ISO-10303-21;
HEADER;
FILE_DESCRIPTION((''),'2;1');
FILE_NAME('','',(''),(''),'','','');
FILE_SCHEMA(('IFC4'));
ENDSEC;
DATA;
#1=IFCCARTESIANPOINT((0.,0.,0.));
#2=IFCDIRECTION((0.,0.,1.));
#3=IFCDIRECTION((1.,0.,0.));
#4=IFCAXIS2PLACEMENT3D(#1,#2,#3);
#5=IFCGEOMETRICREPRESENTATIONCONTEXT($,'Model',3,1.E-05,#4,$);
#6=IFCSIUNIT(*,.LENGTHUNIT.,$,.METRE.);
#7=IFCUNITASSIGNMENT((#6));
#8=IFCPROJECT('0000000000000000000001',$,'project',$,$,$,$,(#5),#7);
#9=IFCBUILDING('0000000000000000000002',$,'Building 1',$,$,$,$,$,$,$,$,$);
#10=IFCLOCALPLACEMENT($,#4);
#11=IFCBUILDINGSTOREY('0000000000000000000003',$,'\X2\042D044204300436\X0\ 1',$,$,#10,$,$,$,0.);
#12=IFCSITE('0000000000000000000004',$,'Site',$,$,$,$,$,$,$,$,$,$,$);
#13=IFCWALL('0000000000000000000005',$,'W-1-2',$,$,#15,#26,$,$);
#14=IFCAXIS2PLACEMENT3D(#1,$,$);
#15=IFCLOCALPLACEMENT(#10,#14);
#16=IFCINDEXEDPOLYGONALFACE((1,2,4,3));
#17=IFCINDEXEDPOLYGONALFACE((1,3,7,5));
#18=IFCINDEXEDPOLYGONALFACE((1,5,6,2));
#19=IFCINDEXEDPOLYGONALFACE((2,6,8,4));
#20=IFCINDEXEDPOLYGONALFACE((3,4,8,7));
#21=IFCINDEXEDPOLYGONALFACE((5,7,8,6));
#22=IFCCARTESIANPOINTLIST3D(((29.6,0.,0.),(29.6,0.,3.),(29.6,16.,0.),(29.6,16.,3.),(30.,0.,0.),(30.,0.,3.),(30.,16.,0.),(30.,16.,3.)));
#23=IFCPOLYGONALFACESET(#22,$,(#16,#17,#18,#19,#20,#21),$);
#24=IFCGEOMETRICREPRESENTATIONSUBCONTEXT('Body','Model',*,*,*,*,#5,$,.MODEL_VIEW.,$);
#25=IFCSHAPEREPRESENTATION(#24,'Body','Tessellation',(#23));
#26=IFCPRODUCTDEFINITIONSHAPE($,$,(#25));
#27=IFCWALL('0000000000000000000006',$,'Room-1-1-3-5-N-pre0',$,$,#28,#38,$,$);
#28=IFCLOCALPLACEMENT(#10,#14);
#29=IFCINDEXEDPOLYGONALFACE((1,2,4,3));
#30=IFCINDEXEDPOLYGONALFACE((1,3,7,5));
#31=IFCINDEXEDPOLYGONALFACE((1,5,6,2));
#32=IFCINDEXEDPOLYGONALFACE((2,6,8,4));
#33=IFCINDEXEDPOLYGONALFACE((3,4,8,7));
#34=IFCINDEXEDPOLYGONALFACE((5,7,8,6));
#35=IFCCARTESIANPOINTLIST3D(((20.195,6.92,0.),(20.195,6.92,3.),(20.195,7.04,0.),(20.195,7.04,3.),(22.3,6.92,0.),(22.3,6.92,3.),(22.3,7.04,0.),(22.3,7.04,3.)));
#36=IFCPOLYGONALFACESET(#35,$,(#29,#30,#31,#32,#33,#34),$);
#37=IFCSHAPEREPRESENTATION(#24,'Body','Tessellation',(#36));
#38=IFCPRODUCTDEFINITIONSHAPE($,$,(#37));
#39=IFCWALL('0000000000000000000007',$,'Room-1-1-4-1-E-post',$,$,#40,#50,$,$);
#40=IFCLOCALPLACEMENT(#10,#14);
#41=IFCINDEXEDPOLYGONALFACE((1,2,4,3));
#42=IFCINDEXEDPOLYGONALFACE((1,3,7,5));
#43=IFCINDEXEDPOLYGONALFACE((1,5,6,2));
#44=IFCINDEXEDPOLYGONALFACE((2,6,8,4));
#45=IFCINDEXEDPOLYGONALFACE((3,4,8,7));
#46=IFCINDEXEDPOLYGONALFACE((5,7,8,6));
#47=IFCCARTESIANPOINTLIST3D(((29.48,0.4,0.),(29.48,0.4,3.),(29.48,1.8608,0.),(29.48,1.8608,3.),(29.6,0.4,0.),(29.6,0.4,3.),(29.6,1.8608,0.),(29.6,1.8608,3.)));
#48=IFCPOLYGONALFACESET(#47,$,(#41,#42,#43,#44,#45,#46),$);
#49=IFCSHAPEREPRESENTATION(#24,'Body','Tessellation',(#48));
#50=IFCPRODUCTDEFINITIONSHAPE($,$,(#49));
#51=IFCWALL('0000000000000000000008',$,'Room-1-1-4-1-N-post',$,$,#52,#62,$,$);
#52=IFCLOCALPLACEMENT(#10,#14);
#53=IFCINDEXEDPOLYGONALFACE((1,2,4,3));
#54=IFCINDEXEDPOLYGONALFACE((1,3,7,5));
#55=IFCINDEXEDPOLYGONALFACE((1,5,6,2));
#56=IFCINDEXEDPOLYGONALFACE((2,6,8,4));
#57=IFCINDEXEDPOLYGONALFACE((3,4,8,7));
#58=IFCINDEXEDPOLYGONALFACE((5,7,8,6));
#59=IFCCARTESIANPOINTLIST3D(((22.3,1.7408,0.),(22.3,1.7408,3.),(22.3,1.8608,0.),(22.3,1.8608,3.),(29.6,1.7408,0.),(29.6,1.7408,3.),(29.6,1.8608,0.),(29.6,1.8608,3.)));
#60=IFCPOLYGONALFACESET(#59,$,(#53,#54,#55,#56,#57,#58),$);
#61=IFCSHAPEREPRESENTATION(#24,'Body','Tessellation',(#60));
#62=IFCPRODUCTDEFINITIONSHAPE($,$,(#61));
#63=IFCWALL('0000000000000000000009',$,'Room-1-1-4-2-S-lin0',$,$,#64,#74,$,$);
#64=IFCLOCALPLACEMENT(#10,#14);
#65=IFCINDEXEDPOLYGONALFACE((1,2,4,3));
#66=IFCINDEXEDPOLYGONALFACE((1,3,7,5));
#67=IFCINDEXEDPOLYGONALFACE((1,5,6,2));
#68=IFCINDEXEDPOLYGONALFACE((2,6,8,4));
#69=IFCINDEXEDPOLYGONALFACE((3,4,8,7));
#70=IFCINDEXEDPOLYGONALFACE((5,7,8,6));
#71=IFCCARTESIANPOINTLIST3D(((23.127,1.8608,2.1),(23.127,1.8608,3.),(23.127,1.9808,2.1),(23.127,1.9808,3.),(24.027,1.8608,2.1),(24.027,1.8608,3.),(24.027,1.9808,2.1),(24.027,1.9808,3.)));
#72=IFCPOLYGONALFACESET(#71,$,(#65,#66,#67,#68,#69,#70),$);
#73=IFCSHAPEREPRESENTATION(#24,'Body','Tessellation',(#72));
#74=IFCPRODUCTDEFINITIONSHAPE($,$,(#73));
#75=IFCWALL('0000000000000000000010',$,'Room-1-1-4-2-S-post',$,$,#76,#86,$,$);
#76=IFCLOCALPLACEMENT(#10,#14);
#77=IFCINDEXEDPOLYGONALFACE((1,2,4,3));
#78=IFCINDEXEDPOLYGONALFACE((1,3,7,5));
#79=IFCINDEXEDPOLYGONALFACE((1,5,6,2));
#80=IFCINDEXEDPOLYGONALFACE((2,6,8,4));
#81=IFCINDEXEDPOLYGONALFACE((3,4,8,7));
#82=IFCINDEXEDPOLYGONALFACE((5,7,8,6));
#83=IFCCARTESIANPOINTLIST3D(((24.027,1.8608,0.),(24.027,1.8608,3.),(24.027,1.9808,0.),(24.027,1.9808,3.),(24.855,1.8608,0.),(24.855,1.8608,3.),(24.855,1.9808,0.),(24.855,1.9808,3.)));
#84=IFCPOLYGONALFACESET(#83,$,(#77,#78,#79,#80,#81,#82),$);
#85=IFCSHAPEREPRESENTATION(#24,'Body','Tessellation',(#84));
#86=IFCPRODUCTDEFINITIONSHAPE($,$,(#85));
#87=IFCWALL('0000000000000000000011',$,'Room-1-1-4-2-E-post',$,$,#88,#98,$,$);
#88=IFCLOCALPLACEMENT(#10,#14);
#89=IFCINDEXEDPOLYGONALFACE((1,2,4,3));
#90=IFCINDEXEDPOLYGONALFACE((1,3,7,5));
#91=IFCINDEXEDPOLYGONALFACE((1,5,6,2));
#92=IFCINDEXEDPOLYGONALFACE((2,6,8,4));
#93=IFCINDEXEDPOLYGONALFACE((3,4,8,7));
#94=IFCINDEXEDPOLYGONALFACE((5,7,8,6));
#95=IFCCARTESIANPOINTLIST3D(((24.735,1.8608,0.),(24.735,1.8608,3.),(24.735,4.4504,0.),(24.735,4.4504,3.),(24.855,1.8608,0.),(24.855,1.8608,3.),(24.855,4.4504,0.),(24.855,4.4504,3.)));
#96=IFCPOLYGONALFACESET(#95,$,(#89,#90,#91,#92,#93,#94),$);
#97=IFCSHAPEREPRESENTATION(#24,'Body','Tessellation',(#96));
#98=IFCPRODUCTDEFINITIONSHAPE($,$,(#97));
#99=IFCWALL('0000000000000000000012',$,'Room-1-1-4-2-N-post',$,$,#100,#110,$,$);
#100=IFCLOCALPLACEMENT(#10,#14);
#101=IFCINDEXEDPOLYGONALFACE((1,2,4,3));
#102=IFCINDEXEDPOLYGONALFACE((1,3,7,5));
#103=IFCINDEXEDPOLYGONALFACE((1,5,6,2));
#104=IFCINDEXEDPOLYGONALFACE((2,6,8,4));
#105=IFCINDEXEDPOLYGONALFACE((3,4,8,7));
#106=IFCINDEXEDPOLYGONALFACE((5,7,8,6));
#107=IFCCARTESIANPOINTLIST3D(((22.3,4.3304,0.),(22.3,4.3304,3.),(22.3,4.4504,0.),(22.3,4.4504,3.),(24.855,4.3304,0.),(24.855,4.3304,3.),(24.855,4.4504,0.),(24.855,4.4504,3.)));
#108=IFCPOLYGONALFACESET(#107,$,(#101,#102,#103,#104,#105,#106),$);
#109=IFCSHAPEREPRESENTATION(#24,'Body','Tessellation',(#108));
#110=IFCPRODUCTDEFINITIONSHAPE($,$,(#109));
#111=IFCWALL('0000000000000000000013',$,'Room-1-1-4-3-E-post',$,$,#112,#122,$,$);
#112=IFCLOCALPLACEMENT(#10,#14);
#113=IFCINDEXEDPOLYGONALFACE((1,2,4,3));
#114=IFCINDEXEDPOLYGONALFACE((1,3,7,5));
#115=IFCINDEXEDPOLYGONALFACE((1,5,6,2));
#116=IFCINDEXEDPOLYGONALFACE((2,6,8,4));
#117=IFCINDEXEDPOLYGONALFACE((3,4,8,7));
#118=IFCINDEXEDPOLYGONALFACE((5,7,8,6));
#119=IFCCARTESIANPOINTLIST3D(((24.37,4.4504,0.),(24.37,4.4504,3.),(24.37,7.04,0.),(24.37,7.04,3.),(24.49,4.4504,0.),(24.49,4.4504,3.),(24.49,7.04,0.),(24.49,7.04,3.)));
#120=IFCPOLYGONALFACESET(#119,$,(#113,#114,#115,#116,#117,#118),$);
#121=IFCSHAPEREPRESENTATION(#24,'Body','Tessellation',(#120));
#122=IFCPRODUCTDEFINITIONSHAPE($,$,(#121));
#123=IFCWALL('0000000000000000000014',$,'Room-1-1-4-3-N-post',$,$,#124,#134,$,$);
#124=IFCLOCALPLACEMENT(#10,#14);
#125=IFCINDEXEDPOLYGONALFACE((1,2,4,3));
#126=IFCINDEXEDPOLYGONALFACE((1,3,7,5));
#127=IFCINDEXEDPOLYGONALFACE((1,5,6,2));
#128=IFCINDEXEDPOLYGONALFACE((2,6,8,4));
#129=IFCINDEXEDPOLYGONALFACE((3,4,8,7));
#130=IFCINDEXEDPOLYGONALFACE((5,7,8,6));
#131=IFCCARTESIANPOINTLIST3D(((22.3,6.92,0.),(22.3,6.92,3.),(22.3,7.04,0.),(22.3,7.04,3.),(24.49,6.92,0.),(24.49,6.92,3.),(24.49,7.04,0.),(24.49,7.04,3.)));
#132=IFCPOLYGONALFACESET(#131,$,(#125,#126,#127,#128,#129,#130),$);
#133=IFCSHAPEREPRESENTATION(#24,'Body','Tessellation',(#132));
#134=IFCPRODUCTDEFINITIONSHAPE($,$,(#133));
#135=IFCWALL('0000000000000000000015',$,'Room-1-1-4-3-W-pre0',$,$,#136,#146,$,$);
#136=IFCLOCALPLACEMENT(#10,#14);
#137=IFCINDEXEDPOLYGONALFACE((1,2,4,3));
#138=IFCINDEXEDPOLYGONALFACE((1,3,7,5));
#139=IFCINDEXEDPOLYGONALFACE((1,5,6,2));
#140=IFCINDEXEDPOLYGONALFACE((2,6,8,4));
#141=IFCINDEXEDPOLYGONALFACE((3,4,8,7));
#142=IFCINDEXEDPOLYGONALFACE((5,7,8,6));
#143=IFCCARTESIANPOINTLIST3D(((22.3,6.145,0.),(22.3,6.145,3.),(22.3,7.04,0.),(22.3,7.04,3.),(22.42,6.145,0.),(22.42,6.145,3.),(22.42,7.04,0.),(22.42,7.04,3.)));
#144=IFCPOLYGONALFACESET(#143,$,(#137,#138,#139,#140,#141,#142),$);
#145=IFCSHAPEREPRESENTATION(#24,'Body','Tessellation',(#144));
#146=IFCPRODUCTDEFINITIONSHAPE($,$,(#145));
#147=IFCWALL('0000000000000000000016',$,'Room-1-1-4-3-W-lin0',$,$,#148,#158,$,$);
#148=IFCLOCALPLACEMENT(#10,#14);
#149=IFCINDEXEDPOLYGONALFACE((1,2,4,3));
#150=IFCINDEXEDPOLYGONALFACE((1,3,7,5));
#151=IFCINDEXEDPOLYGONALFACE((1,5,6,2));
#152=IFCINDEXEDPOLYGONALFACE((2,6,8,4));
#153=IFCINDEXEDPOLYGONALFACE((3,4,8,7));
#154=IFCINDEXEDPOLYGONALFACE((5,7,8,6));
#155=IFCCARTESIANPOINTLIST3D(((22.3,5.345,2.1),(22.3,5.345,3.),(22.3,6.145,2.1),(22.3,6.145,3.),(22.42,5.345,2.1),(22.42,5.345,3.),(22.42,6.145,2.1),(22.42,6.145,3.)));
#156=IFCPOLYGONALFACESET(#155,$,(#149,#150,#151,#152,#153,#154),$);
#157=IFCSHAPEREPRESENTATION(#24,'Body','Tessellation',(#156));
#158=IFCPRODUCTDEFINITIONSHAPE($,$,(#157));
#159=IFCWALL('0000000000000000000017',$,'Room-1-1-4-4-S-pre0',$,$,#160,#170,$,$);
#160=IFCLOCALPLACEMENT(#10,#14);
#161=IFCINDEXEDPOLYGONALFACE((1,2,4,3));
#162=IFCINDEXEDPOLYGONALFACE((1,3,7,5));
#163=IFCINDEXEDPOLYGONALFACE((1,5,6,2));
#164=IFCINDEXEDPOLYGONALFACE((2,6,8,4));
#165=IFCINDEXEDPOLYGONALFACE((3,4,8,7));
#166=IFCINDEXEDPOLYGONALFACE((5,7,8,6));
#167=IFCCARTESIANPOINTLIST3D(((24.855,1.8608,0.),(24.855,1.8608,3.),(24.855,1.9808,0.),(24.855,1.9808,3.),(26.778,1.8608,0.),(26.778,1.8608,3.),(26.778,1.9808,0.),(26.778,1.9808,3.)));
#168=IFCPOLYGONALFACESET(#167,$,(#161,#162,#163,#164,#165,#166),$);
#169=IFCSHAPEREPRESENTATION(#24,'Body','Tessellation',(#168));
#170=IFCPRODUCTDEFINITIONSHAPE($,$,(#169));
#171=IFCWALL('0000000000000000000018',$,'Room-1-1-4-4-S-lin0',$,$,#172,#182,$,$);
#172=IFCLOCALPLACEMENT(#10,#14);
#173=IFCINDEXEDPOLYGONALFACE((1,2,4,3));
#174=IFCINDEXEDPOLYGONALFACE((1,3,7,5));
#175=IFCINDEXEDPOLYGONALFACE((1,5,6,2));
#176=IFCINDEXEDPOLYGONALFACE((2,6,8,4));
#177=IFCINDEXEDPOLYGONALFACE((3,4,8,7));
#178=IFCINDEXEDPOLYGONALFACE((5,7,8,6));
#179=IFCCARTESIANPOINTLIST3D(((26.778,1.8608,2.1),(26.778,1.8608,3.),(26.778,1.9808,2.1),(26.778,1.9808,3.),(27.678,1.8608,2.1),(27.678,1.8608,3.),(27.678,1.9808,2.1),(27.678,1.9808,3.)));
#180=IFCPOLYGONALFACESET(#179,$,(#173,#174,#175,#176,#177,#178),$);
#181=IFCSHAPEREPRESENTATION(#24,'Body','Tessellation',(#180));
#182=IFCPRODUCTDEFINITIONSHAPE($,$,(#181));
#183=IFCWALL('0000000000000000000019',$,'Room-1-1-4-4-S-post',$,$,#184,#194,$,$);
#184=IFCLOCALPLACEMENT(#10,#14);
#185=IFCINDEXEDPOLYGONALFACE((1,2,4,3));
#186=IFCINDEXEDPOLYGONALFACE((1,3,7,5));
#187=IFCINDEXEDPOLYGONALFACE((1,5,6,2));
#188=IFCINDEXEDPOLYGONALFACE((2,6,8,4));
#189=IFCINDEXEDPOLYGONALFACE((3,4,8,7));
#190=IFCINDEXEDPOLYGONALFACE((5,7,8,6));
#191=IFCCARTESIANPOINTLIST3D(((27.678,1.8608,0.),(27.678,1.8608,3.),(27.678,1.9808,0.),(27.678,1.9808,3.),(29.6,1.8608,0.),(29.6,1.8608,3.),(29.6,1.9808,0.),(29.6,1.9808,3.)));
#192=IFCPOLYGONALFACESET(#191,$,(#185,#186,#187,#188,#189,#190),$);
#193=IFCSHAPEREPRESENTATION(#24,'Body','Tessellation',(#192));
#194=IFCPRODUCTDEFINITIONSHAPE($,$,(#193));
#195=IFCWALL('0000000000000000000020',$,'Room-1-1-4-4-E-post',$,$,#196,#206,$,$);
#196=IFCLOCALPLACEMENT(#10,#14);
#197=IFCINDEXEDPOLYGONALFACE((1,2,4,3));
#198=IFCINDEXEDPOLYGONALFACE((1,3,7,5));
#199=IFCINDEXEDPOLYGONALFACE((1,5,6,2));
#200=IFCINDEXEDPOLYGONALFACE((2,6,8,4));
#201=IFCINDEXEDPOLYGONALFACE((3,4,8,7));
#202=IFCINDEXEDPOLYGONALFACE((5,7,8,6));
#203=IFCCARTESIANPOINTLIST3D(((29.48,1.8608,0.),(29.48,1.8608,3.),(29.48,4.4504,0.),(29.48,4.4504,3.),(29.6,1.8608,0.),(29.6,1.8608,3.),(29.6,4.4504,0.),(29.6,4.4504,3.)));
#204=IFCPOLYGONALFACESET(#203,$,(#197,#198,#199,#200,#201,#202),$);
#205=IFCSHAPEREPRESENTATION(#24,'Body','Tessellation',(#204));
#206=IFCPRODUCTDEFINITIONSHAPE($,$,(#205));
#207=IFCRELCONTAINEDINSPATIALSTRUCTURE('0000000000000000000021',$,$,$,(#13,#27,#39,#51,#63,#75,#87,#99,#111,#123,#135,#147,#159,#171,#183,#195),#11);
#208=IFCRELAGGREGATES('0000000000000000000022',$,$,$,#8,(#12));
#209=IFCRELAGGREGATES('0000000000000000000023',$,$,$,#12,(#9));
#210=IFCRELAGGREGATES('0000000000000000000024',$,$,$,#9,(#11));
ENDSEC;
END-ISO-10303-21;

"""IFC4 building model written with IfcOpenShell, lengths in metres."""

from ifc_helpers import new_model, si_unit, frame, origin_with_axes, place, context, subcontext, project, spatial, indexed_curve, outline, extrude, element, save


model = new_model("IFC4")

# Units and contexts
model_context = context("Model", 3, precision=1e-05, world=origin_with_axes())
body_context = subcontext(model_context, "Body", "Model", "MODEL_VIEW")
ifc_project = project(units=[si_unit("LENGTHUNIT", "METRE")], contexts=[model_context])

# Site, building, storey
site = spatial("IfcSite", under=ifc_project, Name="Site")
building = spatial("IfcBuilding", under=site, Name="Building 1")
storey_placement = place(None, origin_with_axes())
storey = spatial("IfcBuildingStorey", under=building, at=storey_placement, Name="Этаж 1", Elevation=0.0)

# Walls
wall_1_placement = place(storey_placement, frame((30.0, 0.0, 0.0), z_axis=(0.0, 0.0, 1.0), x_axis=(0.0, 1.0, 0.0)))
element("IfcWall", 1, at=wall_1_placement, inside=storey, Name="W-1-2", context=body_context, shape_type="SweptSolid", body=[
    extrude(outline(indexed_curve([(0.0, 0.0), (0.0, 0.4), (16.0, 0.4), (16.0, 0.0), (0.0, 0.0)], self_intersect=False)), origin_with_axes(), (0.0, 0.0, 1.0), 3.0),
])
wall_2_placement = place(storey_placement, frame((22.3, 7.04, 0.0), z_axis=(0.0, 0.0, 1.0), x_axis=(-1.0, 0.0, 0.0)))
element("IfcWall", 2, at=wall_2_placement, inside=storey, Name="Room-1-1-3-5-N-pre0", context=body_context, shape_type="SweptSolid", body=[
    extrude(outline(indexed_curve([(0.0, 0.0), (0.0, 0.12), (2.105, 0.12), (2.105, 0.0), (0.0, 0.0)], self_intersect=False)), origin_with_axes(), (0.0, 0.0, 1.0), 3.0),
])
wall_3_placement = place(storey_placement, frame((29.6, 0.4, 0.0), z_axis=(0.0, 0.0, 1.0), x_axis=(0.0, 1.0, 0.0)))
element("IfcWall", 3, at=wall_3_placement, inside=storey, Name="Room-1-1-4-1-E-post", context=body_context, shape_type="SweptSolid", body=[
    extrude(outline(indexed_curve([(0.0, 0.0), (0.0, 0.12), (1.4608, 0.12), (1.4608, 0.0), (0.0, 0.0)], self_intersect=False)), origin_with_axes(), (0.0, 0.0, 1.0), 3.0),
])
wall_4_placement = place(storey_placement, frame((29.6, 1.8608, 0.0), z_axis=(0.0, 0.0, 1.0), x_axis=(-1.0, 0.0, 0.0)))
element("IfcWall", 4, at=wall_4_placement, inside=storey, Name="Room-1-1-4-1-N-post", context=body_context, shape_type="SweptSolid", body=[
    extrude(outline(indexed_curve([(0.0, 0.0), (0.0, 0.12), (7.3, 0.12), (7.3, 0.0), (0.0, 0.0)], self_intersect=False)), origin_with_axes(), (0.0, 0.0, 1.0), 3.0),
])
wall_5_placement = place(storey_placement, frame((23.127, 1.8608, 2.1), z_axis=(0.0, 0.0, 1.0), x_axis=(1.0, 0.0, 0.0)))
element("IfcWall", 5, at=wall_5_placement, inside=storey, Name="Room-1-1-4-2-S-lin0", context=body_context, shape_type="SweptSolid", body=[
    extrude(outline(indexed_curve([(0.0, 0.0), (0.0, 0.12), (0.9, 0.12), (0.9, 0.0), (0.0, 0.0)], self_intersect=False)), origin_with_axes(), (0.0, 0.0, 1.0), 0.9),
])
wall_6_placement = place(storey_placement, frame((24.027, 1.8608, 0.0), z_axis=(0.0, 0.0, 1.0), x_axis=(1.0, 0.0, 0.0)))
element("IfcWall", 6, at=wall_6_placement, inside=storey, Name="Room-1-1-4-2-S-post", context=body_context, shape_type="SweptSolid", body=[
    extrude(outline(indexed_curve([(0.0, 0.0), (0.0, 0.12), (0.828, 0.12), (0.828, 0.0), (0.0, 0.0)], self_intersect=False)), origin_with_axes(), (0.0, 0.0, 1.0), 3.0),
])
wall_7_placement = place(storey_placement, frame((24.855, 1.8608, 0.0), z_axis=(0.0, 0.0, 1.0), x_axis=(0.0, 1.0, 0.0)))
element("IfcWall", 7, at=wall_7_placement, inside=storey, Name="Room-1-1-4-2-E-post", context=body_context, shape_type="SweptSolid", body=[
    extrude(outline(indexed_curve([(0.0, 0.0), (0.0, 0.12), (2.5896, 0.12), (2.5896, 0.0), (0.0, 0.0)], self_intersect=False)), origin_with_axes(), (0.0, 0.0, 1.0), 3.0),
])
wall_8_placement = place(storey_placement, frame((24.855, 4.4504, 0.0), z_axis=(0.0, 0.0, 1.0), x_axis=(-1.0, 0.0, 0.0)))
element("IfcWall", 8, at=wall_8_placement, inside=storey, Name="Room-1-1-4-2-N-post", context=body_context, shape_type="SweptSolid", body=[
    extrude(outline(indexed_curve([(0.0, 0.0), (0.0, 0.12), (2.555, 0.12), (2.555, 0.0), (0.0, 0.0)], self_intersect=False)), origin_with_axes(), (0.0, 0.0, 1.0), 3.0),
])
wall_9_placement = place(storey_placement, frame((24.49, 4.4504, 0.0), z_axis=(0.0, 0.0, 1.0), x_axis=(0.0, 1.0, 0.0)))
element("IfcWall", 9, at=wall_9_placement, inside=storey, Name="Room-1-1-4-3-E-post", context=body_context, shape_type="SweptSolid", body=[
    extrude(outline(indexed_curve([(0.0, 0.0), (0.0, 0.12), (2.5896, 0.12), (2.5896, 0.0), (0.0, 0.0)], self_intersect=False)), origin_with_axes(), (0.0, 0.0, 1.0), 3.0),
])
wall_10_placement = place(storey_placement, frame((24.49, 7.04, 0.0), z_axis=(0.0, 0.0, 1.0), x_axis=(-1.0, 0.0, 0.0)))
element("IfcWall", 10, at=wall_10_placement, inside=storey, Name="Room-1-1-4-3-N-post", context=body_context, shape_type="SweptSolid", body=[
    extrude(outline(indexed_curve([(0.0, 0.0), (0.0, 0.12), (2.19, 0.12), (2.19, 0.0), (0.0, 0.0)], self_intersect=False)), origin_with_axes(), (0.0, 0.0, 1.0), 3.0),
])
wall_11_placement = place(storey_placement, frame((22.3, 7.04, 0.0), z_axis=(0.0, 0.0, 1.0), x_axis=(0.0, -1.0, 0.0)))
element("IfcWall", 11, at=wall_11_placement, inside=storey, Name="Room-1-1-4-3-W-pre0", context=body_context, shape_type="SweptSolid", body=[
    extrude(outline(indexed_curve([(0.0, 0.0), (0.0, 0.12), (0.895, 0.12), (0.895, 0.0), (0.0, 0.0)], self_intersect=False)), origin_with_axes(), (0.0, 0.0, 1.0), 3.0),
])
wall_12_placement = place(storey_placement, frame((22.3, 6.145, 2.1), z_axis=(0.0, 0.0, 1.0), x_axis=(0.0, -1.0, 0.0)))
element("IfcWall", 12, at=wall_12_placement, inside=storey, Name="Room-1-1-4-3-W-lin0", context=body_context, shape_type="SweptSolid", body=[
    extrude(outline(indexed_curve([(0.0, 0.0), (0.0, 0.12), (0.8, 0.12), (0.8, 0.0), (0.0, 0.0)], self_intersect=False)), origin_with_axes(), (0.0, 0.0, 1.0), 0.9),
])
wall_13_placement = place(storey_placement, frame((24.855, 1.8608, 0.0), z_axis=(0.0, 0.0, 1.0), x_axis=(1.0, 0.0, 0.0)))
element("IfcWall", 13, at=wall_13_placement, inside=storey, Name="Room-1-1-4-4-S-pre0", context=body_context, shape_type="SweptSolid", body=[
    extrude(outline(indexed_curve([(0.0, 0.0), (0.0, 0.12), (1.923, 0.12), (1.923, 0.0), (0.0, 0.0)], self_intersect=False)), origin_with_axes(), (0.0, 0.0, 1.0), 3.0),
])
wall_14_placement = place(storey_placement, frame((26.778, 1.8608, 2.1), z_axis=(0.0, 0.0, 1.0), x_axis=(1.0, 0.0, 0.0)))
element("IfcWall", 14, at=wall_14_placement, inside=storey, Name="Room-1-1-4-4-S-lin0", context=body_context, shape_type="SweptSolid", body=[
    extrude(outline(indexed_curve([(0.0, 0.0), (0.0, 0.12), (0.9, 0.12), (0.9, 0.0), (0.0, 0.0)], self_intersect=False)), origin_with_axes(), (0.0, 0.0, 1.0), 0.9),
])
wall_15_placement = place(storey_placement, frame((27.678, 1.8608, 0.0), z_axis=(0.0, 0.0, 1.0), x_axis=(1.0, 0.0, 0.0)))
element("IfcWall", 15, at=wall_15_placement, inside=storey, Name="Room-1-1-4-4-S-post", context=body_context, shape_type="SweptSolid", body=[
    extrude(outline(indexed_curve([(0.0, 0.0), (0.0, 0.12), (1.922, 0.12), (1.922, 0.0), (0.0, 0.0)], self_intersect=False)), origin_with_axes(), (0.0, 0.0, 1.0), 3.0),
])
wall_16_placement = place(storey_placement, frame((29.6, 1.8608, 0.0), z_axis=(0.0, 0.0, 1.0), x_axis=(0.0, 1.0, 0.0)))
element("IfcWall", 16, at=wall_16_placement, inside=storey, Name="Room-1-1-4-4-E-post", context=body_context, shape_type="SweptSolid", body=[
    extrude(outline(indexed_curve([(0.0, 0.0), (0.0, 0.12), (2.5896, 0.12), (2.5896, 0.0), (0.0, 0.0)], self_intersect=False)), origin_with_axes(), (0.0, 0.0, 1.0), 3.0),
])

save(model, "model.ifc")
